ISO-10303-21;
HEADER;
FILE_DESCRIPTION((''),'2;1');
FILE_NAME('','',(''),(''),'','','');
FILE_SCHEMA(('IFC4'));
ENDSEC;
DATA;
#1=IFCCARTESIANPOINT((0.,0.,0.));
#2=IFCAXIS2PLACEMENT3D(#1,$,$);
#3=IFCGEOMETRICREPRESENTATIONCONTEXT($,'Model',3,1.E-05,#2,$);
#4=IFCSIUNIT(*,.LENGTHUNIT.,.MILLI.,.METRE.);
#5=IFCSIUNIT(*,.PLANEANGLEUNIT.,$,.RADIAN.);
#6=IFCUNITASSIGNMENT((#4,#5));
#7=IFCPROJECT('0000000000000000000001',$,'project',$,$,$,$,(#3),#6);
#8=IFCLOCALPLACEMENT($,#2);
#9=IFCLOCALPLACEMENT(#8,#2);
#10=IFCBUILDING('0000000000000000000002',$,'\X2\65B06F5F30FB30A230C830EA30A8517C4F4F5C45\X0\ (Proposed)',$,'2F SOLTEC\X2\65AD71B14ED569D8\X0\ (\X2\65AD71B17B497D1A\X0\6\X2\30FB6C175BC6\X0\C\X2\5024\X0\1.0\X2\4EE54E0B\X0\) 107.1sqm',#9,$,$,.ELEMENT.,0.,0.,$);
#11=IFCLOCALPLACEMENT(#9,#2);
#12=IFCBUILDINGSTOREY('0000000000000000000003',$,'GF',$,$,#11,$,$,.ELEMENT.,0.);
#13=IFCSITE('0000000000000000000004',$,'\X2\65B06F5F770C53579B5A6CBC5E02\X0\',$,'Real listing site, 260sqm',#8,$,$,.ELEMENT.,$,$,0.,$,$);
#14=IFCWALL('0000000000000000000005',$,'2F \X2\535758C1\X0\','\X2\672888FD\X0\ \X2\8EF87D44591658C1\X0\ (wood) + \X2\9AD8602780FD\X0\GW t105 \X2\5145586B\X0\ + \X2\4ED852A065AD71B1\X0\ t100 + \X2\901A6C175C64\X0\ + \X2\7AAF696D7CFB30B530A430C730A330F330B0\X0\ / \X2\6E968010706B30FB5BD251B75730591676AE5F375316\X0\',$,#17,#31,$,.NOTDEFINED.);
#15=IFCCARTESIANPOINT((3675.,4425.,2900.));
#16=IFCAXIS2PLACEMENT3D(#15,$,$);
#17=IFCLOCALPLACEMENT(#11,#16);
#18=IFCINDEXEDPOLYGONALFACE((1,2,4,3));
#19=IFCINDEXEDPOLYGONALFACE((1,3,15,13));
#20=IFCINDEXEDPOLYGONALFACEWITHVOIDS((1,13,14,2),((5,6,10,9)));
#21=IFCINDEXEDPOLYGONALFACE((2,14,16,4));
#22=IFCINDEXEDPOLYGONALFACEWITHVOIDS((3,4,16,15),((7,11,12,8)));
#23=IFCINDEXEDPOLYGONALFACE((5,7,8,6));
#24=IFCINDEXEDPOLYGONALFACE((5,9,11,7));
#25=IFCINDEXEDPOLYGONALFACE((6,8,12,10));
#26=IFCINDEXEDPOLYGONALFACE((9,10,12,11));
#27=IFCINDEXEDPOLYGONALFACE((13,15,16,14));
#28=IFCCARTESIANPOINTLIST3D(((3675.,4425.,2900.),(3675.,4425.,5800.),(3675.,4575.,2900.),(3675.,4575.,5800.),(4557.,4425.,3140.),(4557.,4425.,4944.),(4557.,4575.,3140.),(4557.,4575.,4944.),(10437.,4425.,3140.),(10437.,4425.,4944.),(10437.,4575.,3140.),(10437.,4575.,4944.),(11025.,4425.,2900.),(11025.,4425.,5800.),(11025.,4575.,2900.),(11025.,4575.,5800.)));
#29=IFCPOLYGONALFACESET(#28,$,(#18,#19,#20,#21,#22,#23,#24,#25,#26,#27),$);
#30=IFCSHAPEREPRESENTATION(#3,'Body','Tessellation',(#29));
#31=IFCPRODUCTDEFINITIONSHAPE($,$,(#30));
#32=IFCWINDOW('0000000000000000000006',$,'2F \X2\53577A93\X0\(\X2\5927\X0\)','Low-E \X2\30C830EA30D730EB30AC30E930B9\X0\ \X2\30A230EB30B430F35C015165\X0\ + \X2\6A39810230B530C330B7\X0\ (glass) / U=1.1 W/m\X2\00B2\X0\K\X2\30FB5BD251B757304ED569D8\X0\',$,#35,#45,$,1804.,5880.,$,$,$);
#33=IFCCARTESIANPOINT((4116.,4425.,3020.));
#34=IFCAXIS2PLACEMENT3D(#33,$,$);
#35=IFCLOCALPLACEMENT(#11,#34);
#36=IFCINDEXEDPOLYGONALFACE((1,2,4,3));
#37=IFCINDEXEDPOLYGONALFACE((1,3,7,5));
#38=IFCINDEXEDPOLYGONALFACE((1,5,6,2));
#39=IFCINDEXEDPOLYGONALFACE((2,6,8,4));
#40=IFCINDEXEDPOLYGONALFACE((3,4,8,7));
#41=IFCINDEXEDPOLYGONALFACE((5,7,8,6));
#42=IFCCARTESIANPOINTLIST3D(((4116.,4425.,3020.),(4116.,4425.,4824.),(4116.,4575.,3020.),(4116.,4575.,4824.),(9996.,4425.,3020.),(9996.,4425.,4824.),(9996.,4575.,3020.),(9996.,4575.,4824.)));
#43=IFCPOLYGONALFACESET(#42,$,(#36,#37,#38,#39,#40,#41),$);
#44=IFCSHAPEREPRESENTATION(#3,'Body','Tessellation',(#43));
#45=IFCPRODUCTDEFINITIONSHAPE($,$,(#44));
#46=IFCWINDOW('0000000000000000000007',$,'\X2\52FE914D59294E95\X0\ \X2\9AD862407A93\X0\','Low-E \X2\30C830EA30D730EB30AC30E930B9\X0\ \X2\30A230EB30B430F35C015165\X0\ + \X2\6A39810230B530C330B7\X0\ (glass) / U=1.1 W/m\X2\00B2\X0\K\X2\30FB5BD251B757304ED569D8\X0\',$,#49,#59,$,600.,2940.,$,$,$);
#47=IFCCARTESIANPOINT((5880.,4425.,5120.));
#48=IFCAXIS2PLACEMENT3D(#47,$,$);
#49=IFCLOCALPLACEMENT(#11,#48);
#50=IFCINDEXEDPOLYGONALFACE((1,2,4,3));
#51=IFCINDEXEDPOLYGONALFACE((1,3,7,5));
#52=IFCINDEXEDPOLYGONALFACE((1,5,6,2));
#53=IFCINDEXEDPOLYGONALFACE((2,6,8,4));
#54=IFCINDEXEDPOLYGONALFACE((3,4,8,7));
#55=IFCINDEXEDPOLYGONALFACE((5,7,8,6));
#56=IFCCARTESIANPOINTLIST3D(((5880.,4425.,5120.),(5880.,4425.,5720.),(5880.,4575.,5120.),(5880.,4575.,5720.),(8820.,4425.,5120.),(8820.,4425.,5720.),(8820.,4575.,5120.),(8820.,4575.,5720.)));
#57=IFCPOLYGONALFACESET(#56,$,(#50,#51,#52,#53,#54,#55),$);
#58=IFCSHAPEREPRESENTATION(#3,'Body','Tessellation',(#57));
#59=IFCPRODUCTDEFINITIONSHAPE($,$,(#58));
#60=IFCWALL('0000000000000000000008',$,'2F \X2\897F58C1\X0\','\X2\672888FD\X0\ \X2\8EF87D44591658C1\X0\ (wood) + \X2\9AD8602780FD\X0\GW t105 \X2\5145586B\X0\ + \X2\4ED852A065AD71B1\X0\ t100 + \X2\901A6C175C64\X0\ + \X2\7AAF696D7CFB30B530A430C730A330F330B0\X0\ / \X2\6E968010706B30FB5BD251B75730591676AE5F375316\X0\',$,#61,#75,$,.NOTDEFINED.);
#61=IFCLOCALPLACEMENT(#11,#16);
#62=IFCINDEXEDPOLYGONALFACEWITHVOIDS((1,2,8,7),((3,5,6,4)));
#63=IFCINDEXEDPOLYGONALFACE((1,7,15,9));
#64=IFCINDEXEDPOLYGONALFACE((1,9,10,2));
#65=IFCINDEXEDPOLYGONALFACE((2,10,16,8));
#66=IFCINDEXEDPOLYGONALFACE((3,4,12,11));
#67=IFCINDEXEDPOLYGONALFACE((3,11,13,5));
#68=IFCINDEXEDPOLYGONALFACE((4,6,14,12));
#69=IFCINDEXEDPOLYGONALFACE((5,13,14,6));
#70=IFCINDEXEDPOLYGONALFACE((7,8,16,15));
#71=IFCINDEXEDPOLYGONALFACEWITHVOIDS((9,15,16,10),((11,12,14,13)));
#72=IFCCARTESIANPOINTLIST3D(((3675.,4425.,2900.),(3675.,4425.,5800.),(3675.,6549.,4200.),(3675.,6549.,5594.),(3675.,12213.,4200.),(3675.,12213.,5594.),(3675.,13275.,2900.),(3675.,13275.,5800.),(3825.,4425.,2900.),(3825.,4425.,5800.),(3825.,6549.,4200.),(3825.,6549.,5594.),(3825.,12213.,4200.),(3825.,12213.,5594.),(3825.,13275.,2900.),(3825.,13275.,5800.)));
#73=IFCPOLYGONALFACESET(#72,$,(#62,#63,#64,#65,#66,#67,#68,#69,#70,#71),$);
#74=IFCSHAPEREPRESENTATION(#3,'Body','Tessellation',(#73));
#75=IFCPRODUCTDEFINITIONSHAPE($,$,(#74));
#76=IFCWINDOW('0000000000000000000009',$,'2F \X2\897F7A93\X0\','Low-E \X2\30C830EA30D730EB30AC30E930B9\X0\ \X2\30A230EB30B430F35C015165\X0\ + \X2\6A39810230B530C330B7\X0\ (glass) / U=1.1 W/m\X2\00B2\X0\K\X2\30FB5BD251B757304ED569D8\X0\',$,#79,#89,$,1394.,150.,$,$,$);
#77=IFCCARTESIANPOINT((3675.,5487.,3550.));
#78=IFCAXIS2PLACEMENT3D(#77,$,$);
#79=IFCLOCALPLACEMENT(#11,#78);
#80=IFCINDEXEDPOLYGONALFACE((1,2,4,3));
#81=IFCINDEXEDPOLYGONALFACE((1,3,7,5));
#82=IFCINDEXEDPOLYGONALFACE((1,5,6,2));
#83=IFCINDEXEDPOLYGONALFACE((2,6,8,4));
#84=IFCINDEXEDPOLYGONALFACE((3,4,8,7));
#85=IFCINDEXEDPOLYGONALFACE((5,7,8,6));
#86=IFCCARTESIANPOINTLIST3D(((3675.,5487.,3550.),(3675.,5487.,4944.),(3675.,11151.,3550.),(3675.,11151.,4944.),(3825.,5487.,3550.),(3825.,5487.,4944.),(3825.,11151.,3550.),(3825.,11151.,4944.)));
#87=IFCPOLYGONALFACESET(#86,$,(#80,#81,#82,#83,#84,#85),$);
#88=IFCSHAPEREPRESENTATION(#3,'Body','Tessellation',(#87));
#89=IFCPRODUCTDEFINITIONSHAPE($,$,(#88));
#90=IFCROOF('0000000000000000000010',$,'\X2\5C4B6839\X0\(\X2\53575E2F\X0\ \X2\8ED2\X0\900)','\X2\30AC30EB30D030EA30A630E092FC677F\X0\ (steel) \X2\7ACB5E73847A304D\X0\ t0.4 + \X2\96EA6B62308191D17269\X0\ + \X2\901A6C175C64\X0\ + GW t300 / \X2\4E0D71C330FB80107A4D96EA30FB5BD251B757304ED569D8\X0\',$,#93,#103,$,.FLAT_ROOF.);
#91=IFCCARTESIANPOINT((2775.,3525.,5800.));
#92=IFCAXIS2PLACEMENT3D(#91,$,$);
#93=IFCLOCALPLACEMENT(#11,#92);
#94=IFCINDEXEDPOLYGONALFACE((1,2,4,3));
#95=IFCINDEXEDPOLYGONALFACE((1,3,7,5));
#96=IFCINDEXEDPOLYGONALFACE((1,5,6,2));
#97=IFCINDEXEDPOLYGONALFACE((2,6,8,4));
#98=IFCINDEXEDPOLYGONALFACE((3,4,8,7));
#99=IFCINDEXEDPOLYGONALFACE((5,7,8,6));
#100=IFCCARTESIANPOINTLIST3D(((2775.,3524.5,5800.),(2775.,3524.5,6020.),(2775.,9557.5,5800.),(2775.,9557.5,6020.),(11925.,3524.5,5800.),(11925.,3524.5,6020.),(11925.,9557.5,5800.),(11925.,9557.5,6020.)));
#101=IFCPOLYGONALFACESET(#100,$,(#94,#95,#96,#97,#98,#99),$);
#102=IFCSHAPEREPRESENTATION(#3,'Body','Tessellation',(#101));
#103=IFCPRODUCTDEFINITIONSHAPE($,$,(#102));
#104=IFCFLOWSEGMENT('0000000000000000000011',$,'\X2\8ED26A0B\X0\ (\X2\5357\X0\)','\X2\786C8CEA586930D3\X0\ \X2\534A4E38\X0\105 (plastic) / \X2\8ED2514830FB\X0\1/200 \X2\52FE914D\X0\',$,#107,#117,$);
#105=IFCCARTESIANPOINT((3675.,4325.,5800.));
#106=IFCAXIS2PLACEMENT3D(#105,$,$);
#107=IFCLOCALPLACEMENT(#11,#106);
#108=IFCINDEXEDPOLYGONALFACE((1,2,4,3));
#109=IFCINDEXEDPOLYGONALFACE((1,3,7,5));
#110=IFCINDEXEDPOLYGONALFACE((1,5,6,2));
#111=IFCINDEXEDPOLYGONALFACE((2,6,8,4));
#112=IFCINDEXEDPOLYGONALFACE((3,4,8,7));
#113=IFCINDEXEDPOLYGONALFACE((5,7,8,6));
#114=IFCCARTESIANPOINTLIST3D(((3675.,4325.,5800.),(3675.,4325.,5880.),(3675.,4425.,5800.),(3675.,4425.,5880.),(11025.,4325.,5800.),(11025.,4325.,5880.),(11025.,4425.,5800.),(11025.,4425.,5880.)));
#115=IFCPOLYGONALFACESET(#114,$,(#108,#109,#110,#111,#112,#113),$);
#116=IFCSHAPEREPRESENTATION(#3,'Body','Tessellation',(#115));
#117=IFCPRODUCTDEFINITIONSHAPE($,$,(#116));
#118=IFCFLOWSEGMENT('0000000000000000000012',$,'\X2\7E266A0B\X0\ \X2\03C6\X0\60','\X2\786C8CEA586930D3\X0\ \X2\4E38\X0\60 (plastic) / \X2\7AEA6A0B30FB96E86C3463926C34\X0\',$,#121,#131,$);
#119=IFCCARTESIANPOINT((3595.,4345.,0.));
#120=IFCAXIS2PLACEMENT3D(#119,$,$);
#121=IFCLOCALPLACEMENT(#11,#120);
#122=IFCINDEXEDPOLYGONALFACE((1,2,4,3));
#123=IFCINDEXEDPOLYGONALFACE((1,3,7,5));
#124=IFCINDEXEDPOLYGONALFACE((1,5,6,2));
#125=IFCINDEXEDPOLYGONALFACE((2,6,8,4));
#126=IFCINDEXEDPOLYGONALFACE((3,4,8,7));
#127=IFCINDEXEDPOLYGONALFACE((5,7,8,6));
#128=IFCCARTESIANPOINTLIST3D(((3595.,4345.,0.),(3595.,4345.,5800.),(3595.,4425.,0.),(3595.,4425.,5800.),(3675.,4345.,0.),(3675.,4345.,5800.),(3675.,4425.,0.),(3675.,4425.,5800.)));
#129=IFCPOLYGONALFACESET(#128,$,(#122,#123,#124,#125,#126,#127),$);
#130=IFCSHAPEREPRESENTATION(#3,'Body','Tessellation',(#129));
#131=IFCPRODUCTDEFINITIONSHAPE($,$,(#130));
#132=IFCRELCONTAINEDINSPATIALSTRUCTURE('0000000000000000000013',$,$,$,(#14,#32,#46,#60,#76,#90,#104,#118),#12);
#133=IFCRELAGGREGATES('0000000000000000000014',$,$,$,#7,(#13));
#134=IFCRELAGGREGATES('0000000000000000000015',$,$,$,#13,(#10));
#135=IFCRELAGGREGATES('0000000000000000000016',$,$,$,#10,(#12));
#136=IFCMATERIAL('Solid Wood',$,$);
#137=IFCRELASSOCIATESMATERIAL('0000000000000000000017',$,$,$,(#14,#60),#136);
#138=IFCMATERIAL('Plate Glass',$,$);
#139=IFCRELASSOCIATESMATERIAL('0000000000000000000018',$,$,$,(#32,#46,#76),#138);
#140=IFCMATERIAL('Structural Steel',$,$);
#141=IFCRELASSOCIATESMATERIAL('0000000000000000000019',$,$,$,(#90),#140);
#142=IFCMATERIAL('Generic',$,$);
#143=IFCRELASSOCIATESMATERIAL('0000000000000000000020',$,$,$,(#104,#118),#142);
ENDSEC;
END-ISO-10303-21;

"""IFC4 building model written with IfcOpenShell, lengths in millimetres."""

from ifc_helpers import new_model, si_unit, frame, frame_2d, origin, place, context, project, spatial, rectangle, extrude, material, element, fill, save


model = new_model("IFC4")

# Units and contexts
model_context = context("Model", 3, precision=1e-05, world=origin())
ifc_project = project(units=[si_unit("LENGTHUNIT", "METRE", prefix="MILLI"), si_unit("PLANEANGLEUNIT", "RADIAN")], contexts=[model_context])

# Site, building, storey
site_placement = place(None, origin())
site = spatial("IfcSite", under=ifc_project, at=site_placement, Name="新潟県南魚沼市", ObjectType="Real listing site, 260sqm", CompositionType="ELEMENT", RefElevation=0.0)
building_placement = place(site_placement, origin())
building = spatial("IfcBuilding", under=site, at=building_placement, Name="新潟・アトリエ兼住居 (Proposed)", ObjectType="2F SOLTEC断熱仕様 (断熱等級6・気密C値1.0以下) 107.1sqm", CompositionType="ELEMENT", ElevationOfRefHeight=0.0, ElevationOfTerrain=0.0)
storey_placement = place(building_placement, origin())
storey = spatial("IfcBuildingStorey", under=building, at=storey_placement, Name="GF", CompositionType="ELEMENT", Elevation=0.0)

# Shared definitions
ifc_material_1 = material(Name="Solid Wood")

# Shared definitions
ifc_material_2 = material(Name="Plate Glass")

# Wall, openings, windows
wall_1_placement = place(storey_placement, frame((3675.0, 4425.0, 2900.0)))
wall_1 = element("IfcWall", 1, at=wall_1_placement, inside=storey, material=ifc_material_1, Name="2F 南壁", Description="木製 軸組外壁 (wood) + 高性能GW t105 充填 + 付加断熱 t100 + 通気層 + 窯業系サイディング / 準耐火・寒冷地外皮強化", PredefinedType="NOTDEFINED", context=model_context, shape_type="SweptSolid", body=[
    extrude(rectangle(XDim=7350.0, YDim=150.0, at=frame_2d((3675.0, 75.0))), frame((3675.0, 4425.0, 2900.0)), (0.0, 0.0, 1.0), 2900.0),
])
opening_1_placement = place(storey_placement, frame((4116.0, 4425.0, 3020.0)))
opening_1 = element("IfcOpeningElement", 2, at=opening_1_placement, cuts=wall_1, PredefinedType="NOTDEFINED", context=model_context, shape_type="SweptSolid", body=[
    extrude(rectangle(XDim=5880.0, YDim=150.0, at=frame_2d((2940.0, 75.0))), frame((4116.0, 4425.0, 3020.0)), (0.0, 0.0, 1.0), 1804.0),
])
opening_2_placement = place(storey_placement, frame((5880.0, 4425.0, 5120.0)))
opening_2 = element("IfcOpeningElement", 3, at=opening_2_placement, cuts=wall_1, PredefinedType="NOTDEFINED", context=model_context, shape_type="SweptSolid", body=[
    extrude(rectangle(XDim=2940.0, YDim=150.0, at=frame_2d((1470.0, 75.0))), frame((5880.0, 4425.0, 5120.0)), (0.0, 0.0, 1.0), 600.0),
])
window_1_placement = place(storey_placement, frame((4116.0, 4425.0, 3020.0)))
window_1 = element("IfcWindow", 4, at=window_1_placement, inside=storey, material=ifc_material_2, Name="2F 南窓(大)", Description="Low-E トリプルガラス アルゴン封入 + 樹脂サッシ (glass) / U=1.1 W/m²K・寒冷地仕様", OverallHeight=1804.0, OverallWidth=5880.0, context=model_context, shape_type="SweptSolid", body=[
    extrude(rectangle(XDim=5880.0, YDim=150.0, at=frame_2d((2940.0, 75.0))), frame((4116.0, 4425.0, 3020.0)), (0.0, 0.0, 1.0), 1804.0),
])
fill(opening_1, window_1)
window_2_placement = place(storey_placement, frame((5880.0, 4425.0, 5120.0)))
window_2 = element("IfcWindow", 5, at=window_2_placement, inside=storey, material=ifc_material_2, Name="勾配天井 高所窓", Description="Low-E トリプルガラス アルゴン封入 + 樹脂サッシ (glass) / U=1.1 W/m²K・寒冷地仕様", OverallHeight=600.0, OverallWidth=2940.0, context=model_context, shape_type="SweptSolid", body=[
    extrude(rectangle(XDim=2940.0, YDim=150.0, at=frame_2d((1470.0, 75.0))), frame((5880.0, 4425.0, 5120.0)), (0.0, 0.0, 1.0), 600.0),
])
fill(opening_2, window_2)

# Wall, opening, window
wall_2_placement = place(storey_placement, frame((3675.0, 4425.0, 2900.0)))
wall_2 = element("IfcWall", 6, at=wall_2_placement, inside=storey, material=ifc_material_1, Name="2F 西壁", Description="木製 軸組外壁 (wood) + 高性能GW t105 充填 + 付加断熱 t100 + 通気層 + 窯業系サイディング / 準耐火・寒冷地外皮強化", PredefinedType="NOTDEFINED", context=model_context, shape_type="SweptSolid", body=[
    extrude(rectangle(XDim=150.0, YDim=8850.0, at=frame_2d((75.0, 4425.0))), frame((3675.0, 4425.0, 2900.0)), (0.0, 0.0, 1.0), 2900.0),
])
opening_3_placement = place(storey_placement, frame((3675.0, 5487.0, 3550.0)))
opening_3 = element("IfcOpeningElement", 7, at=opening_3_placement, cuts=wall_2, PredefinedType="NOTDEFINED", context=model_context, shape_type="SweptSolid", body=[
    extrude(rectangle(XDim=150.0, YDim=5664.0, at=frame_2d((75.0, 2832.0))), frame((3675.0, 5487.0, 3550.0)), (0.0, 0.0, 1.0), 1394.0),
])
window_3_placement = place(storey_placement, frame((3675.0, 5487.0, 3550.0)))
window_3 = element("IfcWindow", 8, at=window_3_placement, inside=storey, material=ifc_material_2, Name="2F 西窓", Description="Low-E トリプルガラス アルゴン封入 + 樹脂サッシ (glass) / U=1.1 W/m²K・寒冷地仕様", OverallHeight=1394.0, OverallWidth=150.0, context=model_context, shape_type="SweptSolid", body=[
    extrude(rectangle(XDim=150.0, YDim=5664.0, at=frame_2d((75.0, 2832.0))), frame((3675.0, 5487.0, 3550.0)), (0.0, 0.0, 1.0), 1394.0),
])
fill(opening_3, window_3)

# Roof
ifc_material_3 = material(Name="Structural Steel")
for number, where, name in (
    (9, (2775.0, 3525.0, 5800.0), "屋根(南帯 軒900)"),
):
    element("IfcRoof", number, at=place(storey_placement, frame(where)), inside=storey, material=ifc_material_3, Name=name, Description="ガルバリウム鋼板 (steel) 立平葺き t0.4 + 雪止め金物 + 通気層 + GW t300 / 不燃・耐積雪・寒冷地仕様", PredefinedType="FLAT_ROOF", context=model_context, shape_type="SweptSolid", body=[
        extrude(rectangle(XDim=9150.0, YDim=6033.0, at=frame_2d((4575.0, 3016.0))), frame((2775.0, 3525.0, 5800.0)), (0.0, 0.0, 1.0), 220.0),
    ])

# Flow segments
ifc_material_4 = material(Name="Generic")
flow_segment_1_placement = place(storey_placement, frame((3675.0, 4325.0, 5800.0)))
element("IfcFlowSegment", 10, at=flow_segment_1_placement, inside=storey, material=ifc_material_4, Name="軒樋 (南)", Description="硬質塩ビ 半丸105 (plastic) / 軒先・1/200 勾配", context=model_context, shape_type="SweptSolid", body=[
    extrude(rectangle(XDim=7350.0, YDim=100.0, at=frame_2d((3675.0, 50.0))), frame((3675.0, 4325.0, 5800.0)), (0.0, 0.0, 1.0), 80.0),
])
flow_segment_2_placement = place(storey_placement, frame((3595.0, 4345.0, 0.0)))
element("IfcFlowSegment", 11, at=flow_segment_2_placement, inside=storey, material=ifc_material_4, Name="縦樋 φ60", Description="硬質塩ビ 丸60 (plastic) / 竪樋・雨水排水", context=model_context, shape_type="SweptSolid", body=[
    extrude(rectangle(XDim=80.0, YDim=80.0, at=frame_2d((40.0, 40.0))), frame((3595.0, 4345.0, 0.0)), (0.0, 0.0, 1.0), 5800.0),
])

save(model, "model.ifc")
